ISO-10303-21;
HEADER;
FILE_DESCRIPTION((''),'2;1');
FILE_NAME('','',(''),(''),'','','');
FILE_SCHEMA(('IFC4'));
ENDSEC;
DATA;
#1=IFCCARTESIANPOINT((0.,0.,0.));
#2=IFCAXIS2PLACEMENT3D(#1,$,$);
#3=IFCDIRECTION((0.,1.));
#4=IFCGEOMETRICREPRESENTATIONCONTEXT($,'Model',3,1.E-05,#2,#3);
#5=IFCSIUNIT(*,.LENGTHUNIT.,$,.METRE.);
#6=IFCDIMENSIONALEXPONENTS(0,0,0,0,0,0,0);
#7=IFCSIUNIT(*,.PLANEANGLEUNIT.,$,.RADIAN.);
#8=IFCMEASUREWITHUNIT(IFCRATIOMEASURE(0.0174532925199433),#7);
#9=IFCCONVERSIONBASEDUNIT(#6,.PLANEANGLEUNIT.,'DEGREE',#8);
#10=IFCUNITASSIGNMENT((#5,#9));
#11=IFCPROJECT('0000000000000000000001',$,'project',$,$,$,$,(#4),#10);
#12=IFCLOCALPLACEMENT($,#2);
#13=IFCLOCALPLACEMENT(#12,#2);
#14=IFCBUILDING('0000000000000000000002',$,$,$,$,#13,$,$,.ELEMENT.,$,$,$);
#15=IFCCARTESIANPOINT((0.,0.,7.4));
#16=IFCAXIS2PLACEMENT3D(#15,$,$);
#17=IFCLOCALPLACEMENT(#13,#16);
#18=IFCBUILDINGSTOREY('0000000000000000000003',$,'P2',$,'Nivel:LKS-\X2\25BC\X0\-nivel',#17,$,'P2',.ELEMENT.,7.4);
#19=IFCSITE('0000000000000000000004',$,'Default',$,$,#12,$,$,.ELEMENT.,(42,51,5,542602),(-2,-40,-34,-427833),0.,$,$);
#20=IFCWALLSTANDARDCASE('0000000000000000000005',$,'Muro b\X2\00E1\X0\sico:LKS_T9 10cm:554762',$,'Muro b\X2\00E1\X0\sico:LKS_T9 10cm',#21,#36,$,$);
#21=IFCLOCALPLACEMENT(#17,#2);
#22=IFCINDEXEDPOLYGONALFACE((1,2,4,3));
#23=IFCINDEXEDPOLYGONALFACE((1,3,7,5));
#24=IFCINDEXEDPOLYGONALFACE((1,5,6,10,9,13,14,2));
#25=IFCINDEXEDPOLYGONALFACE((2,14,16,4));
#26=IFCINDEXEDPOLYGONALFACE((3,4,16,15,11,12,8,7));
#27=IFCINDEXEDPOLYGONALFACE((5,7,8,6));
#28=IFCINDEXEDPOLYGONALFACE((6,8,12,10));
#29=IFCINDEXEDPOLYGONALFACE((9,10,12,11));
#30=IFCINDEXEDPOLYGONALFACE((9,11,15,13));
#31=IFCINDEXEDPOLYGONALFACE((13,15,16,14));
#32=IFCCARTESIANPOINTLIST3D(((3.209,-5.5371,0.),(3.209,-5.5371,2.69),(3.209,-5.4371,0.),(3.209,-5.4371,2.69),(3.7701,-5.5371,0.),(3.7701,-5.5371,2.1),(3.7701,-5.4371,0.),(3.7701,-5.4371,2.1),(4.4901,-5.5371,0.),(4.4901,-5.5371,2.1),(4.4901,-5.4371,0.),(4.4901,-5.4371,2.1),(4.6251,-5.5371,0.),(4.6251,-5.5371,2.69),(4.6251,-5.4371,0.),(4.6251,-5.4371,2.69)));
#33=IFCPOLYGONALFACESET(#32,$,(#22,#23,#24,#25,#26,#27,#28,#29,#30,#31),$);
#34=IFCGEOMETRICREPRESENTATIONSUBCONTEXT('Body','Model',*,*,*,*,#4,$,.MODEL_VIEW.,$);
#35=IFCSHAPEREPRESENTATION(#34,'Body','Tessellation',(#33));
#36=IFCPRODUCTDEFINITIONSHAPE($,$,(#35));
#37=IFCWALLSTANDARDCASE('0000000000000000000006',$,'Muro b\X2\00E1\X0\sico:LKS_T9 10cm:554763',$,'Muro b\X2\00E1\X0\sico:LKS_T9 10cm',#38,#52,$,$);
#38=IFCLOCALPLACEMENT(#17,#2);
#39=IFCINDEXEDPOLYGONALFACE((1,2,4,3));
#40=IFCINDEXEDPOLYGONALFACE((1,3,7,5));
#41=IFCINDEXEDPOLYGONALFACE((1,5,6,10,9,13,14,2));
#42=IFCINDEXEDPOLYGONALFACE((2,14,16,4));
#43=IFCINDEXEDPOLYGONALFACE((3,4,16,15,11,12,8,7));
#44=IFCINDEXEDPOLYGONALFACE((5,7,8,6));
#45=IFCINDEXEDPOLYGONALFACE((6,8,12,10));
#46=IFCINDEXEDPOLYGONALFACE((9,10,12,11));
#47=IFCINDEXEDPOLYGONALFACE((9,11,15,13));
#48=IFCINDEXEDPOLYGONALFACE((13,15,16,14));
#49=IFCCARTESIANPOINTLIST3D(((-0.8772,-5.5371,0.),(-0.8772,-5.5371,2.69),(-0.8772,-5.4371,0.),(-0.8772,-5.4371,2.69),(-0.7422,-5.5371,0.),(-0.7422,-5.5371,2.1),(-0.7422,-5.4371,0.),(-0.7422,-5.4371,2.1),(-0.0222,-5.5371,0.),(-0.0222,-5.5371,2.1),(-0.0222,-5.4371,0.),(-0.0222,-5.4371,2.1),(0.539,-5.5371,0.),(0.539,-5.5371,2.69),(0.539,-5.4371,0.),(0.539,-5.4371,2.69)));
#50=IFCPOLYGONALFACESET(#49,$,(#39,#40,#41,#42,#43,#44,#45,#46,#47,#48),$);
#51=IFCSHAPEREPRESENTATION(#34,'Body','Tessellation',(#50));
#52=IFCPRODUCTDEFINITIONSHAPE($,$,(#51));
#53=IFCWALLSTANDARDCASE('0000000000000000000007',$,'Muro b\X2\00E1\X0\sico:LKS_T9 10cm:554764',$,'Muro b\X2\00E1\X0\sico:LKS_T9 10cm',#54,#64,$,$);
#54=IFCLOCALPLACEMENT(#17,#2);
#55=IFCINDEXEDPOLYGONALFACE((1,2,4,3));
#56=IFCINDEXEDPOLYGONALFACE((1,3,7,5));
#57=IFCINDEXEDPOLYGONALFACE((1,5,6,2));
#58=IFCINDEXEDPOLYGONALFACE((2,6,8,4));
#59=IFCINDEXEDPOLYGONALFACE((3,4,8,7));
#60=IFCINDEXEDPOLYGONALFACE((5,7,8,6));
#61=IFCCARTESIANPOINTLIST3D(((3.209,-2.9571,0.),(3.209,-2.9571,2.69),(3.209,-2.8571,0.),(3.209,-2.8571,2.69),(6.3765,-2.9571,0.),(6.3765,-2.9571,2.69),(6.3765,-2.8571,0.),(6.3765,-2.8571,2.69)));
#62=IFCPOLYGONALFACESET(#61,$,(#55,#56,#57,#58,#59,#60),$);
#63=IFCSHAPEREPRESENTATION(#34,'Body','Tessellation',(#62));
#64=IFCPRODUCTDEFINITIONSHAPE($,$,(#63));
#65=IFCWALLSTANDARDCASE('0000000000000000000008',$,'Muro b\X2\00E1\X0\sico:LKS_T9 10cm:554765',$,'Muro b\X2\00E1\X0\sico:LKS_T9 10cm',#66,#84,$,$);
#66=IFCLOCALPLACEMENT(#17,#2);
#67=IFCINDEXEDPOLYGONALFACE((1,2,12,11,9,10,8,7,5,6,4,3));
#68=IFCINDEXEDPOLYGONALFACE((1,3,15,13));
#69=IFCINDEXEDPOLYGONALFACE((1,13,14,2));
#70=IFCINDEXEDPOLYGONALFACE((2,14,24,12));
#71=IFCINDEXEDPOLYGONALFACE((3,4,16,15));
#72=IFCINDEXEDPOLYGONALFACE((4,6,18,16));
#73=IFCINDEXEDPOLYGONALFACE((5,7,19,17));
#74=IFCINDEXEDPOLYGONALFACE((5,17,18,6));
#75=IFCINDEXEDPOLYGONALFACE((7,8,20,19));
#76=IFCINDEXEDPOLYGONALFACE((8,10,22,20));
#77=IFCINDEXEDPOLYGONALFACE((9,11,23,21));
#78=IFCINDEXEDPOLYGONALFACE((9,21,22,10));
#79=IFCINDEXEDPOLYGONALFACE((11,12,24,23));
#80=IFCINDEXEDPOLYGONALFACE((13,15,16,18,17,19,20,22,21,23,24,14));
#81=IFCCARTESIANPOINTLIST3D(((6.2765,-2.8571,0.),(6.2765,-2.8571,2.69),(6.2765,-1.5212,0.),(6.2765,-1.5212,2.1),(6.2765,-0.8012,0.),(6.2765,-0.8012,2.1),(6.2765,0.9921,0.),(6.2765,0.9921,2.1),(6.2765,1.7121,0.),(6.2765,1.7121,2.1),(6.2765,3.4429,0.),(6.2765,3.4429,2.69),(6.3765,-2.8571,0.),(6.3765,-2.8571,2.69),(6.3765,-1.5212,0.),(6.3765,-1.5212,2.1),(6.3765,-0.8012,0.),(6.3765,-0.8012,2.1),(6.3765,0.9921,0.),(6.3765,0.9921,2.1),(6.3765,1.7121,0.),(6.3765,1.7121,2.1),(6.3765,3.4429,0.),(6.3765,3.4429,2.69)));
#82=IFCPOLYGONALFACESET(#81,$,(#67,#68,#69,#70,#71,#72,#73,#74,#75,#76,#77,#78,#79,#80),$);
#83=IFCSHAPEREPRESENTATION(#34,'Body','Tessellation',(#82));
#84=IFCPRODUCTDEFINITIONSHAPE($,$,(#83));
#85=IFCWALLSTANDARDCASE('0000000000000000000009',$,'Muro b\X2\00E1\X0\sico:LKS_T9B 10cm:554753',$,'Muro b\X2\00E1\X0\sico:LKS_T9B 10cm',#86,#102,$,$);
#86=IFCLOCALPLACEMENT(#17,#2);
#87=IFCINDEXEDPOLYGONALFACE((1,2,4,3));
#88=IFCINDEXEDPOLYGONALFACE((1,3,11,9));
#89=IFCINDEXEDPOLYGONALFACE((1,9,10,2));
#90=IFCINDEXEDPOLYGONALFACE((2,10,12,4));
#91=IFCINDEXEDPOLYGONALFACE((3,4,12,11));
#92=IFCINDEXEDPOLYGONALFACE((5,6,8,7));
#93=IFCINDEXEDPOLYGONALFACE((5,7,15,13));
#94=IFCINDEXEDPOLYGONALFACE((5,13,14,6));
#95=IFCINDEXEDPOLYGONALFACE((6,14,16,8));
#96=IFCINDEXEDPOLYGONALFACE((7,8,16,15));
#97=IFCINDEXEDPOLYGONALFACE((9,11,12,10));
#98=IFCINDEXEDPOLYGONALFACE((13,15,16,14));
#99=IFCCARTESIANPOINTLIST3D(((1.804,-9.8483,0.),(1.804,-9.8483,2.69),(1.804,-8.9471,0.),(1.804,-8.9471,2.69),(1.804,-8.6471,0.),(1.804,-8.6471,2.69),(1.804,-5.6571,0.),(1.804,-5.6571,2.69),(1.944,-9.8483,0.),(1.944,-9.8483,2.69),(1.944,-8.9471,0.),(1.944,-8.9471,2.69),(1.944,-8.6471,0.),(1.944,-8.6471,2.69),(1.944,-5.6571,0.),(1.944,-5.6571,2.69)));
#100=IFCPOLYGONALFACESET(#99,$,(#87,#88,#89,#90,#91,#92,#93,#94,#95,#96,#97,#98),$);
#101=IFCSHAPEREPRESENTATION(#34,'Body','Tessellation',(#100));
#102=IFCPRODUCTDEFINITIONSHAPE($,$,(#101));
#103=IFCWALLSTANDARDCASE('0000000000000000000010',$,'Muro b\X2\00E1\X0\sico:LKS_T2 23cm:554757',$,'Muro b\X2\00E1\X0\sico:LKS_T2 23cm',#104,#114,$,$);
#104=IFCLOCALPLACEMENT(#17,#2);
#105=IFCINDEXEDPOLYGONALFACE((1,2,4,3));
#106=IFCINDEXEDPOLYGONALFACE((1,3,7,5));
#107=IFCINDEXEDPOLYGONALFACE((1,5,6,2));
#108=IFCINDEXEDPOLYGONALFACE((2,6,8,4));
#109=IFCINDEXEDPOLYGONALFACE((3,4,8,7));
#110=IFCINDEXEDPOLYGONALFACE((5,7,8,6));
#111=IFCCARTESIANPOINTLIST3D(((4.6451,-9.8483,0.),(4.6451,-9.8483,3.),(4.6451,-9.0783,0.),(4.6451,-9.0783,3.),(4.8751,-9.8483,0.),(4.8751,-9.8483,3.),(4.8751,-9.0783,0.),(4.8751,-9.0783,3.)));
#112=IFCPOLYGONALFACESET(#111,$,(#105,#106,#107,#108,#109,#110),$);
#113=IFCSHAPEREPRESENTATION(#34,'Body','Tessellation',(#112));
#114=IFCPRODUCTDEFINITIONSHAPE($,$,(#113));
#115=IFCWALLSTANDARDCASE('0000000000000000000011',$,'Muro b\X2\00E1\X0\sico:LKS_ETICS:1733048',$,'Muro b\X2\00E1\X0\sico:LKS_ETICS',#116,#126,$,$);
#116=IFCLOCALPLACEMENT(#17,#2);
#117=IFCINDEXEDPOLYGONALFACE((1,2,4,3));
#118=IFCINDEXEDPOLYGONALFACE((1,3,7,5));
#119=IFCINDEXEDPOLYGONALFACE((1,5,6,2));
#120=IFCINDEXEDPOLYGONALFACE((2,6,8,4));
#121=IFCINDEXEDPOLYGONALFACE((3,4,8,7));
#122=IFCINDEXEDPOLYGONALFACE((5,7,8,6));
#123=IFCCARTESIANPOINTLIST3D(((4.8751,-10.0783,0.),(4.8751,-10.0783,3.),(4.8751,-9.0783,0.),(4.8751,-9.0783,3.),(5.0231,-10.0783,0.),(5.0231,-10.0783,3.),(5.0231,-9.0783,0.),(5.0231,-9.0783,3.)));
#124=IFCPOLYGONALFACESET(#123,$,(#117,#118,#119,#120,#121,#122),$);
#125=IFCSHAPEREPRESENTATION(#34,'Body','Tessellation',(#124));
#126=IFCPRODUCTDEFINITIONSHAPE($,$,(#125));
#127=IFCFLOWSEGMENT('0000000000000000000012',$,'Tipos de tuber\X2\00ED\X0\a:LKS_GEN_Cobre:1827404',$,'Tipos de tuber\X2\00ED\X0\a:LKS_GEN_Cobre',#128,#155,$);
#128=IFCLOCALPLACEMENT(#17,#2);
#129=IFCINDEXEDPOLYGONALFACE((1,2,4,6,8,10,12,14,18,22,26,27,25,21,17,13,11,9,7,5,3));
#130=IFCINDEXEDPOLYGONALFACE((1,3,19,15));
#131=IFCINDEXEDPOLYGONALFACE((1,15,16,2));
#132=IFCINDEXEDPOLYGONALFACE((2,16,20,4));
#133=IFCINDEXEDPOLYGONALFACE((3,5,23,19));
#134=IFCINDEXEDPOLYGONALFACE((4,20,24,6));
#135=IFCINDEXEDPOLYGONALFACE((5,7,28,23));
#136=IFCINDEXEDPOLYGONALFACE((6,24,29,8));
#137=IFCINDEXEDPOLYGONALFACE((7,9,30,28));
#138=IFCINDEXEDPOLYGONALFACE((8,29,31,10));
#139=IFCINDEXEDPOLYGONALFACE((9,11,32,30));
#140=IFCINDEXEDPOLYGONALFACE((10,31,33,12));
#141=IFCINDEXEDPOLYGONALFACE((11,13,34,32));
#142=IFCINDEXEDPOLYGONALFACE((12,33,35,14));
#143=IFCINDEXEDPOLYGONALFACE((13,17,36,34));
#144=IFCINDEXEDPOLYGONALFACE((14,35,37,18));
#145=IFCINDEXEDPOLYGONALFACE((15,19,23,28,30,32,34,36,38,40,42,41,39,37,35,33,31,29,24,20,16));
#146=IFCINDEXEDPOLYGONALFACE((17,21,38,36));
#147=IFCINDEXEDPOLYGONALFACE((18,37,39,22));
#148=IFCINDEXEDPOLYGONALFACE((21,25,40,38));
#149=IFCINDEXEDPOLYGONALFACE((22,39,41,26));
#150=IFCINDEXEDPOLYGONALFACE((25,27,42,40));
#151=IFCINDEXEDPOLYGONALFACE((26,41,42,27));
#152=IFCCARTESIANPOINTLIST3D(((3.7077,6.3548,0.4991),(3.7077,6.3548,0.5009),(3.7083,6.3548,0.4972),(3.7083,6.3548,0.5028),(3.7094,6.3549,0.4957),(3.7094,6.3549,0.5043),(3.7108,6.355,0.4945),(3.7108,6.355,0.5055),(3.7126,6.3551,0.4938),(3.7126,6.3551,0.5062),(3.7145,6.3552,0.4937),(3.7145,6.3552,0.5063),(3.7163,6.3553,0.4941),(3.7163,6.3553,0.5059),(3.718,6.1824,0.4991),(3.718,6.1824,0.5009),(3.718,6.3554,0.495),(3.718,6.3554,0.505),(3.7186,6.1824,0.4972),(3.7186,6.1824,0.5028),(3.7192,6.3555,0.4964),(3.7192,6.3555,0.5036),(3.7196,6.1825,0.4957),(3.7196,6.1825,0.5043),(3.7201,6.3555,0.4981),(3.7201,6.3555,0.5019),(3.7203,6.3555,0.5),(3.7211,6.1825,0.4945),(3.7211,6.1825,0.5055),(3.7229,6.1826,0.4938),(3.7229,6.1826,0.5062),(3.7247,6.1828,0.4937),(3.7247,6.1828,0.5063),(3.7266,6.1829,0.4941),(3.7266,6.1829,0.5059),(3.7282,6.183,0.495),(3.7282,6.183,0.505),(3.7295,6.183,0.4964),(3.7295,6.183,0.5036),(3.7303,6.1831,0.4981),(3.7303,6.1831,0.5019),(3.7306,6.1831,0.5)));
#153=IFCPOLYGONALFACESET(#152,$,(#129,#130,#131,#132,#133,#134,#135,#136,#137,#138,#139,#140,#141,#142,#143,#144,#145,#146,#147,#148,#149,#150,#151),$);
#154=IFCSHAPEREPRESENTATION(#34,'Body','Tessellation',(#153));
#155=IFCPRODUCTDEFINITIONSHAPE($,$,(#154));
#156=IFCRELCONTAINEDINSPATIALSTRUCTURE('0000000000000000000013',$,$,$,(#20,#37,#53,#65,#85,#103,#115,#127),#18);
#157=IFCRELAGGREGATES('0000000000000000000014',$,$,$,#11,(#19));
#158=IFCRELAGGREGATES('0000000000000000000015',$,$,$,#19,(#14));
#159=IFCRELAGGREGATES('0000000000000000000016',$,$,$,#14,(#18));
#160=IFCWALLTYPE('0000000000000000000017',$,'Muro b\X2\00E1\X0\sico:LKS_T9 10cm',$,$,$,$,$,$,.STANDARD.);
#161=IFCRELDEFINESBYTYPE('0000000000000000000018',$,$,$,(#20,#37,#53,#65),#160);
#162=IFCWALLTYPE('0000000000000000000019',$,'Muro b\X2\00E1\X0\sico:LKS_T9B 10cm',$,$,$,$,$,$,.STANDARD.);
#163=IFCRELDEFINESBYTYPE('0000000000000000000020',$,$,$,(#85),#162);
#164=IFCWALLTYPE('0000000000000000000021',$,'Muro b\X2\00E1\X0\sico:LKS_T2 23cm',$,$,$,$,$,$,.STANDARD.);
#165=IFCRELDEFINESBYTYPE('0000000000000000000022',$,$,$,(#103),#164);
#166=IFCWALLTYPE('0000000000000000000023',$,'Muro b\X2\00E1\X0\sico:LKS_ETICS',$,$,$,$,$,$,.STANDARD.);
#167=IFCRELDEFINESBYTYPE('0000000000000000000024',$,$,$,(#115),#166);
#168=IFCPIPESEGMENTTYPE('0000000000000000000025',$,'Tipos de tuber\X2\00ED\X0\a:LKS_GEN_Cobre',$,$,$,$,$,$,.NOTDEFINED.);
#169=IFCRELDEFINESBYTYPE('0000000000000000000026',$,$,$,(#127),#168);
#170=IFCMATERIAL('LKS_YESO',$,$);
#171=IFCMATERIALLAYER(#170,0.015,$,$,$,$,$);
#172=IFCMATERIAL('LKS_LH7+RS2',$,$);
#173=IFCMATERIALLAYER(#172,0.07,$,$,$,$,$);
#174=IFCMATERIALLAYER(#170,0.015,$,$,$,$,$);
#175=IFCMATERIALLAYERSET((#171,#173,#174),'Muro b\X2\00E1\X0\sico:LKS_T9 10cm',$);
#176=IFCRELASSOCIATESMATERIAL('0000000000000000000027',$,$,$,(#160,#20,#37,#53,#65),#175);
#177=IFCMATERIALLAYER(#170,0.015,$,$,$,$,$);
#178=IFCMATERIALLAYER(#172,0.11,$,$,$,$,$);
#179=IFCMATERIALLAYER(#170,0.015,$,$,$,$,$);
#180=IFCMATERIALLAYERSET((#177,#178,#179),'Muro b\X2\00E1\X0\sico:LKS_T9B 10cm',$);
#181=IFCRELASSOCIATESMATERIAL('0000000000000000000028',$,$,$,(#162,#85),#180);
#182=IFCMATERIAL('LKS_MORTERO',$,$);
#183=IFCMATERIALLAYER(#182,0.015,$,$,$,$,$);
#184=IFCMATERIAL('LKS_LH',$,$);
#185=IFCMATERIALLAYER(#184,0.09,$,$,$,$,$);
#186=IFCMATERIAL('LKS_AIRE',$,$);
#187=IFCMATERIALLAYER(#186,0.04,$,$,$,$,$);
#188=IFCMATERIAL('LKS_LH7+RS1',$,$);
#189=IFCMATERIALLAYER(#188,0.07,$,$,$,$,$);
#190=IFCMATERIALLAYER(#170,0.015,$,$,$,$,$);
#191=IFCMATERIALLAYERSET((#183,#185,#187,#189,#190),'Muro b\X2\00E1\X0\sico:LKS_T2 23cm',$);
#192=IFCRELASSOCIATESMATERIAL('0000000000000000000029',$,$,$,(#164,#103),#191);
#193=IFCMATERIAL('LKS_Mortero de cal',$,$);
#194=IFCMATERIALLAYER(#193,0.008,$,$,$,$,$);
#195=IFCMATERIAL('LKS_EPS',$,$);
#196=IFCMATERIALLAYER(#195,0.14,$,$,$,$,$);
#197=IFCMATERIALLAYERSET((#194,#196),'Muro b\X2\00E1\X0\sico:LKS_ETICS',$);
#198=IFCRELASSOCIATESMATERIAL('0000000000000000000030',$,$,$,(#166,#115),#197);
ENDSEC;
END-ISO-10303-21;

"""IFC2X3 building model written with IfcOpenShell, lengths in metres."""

from ifc_helpers import new_model, entity, si_unit, converted_unit, direction, frame, frame_2d, origin, origin_2d_with_axis, place, context, subcontext, project, spatial, rectangle, circle, extrude, material, layer, layer_set, layer_usage, type_object, element, save


model = new_model("IFC2X3")

# Units and contexts
model_context = context("Model", 3, precision=1e-05, world=origin(), true_north=direction((0.0, 1.0)))
body_context = subcontext(model_context, "Body", "Model", "MODEL_VIEW")
ifc_project = project(units=[si_unit("LENGTHUNIT", "METRE"), converted_unit("PLANEANGLEUNIT", "DEGREE", entity("IfcRatioMeasure", 0.0174532925199433), si_unit("PLANEANGLEUNIT", "RADIAN"), dimensions=[0, 0, 0, 0, 0, 0, 0])], contexts=[model_context])

# Site, building, storey
site_placement = place(None, origin())
site = spatial("IfcSite", under=ifc_project, at=site_placement, Name="Default", CompositionType="ELEMENT", RefLatitude=(42, 51, 5, 542602), RefLongitude=(-2, -40, -34, -427833), RefElevation=0.0)
building_placement = place(site_placement, origin())
building = spatial("IfcBuilding", under=site, at=building_placement, CompositionType="ELEMENT")
storey_placement = place(building_placement, frame((0.0, 0.0, 7.4)))
storey = spatial("IfcBuildingStorey", under=building, at=storey_placement, Name="P2", ObjectType="Nivel:LKS-▼-nivel", LongName="P2", CompositionType="ELEMENT", Elevation=7.4)

# Shared definitions
ifc_material_1 = material(Name="LKS_MORTERO")
ifc_material_2 = material(Name="LKS_LH")
ifc_material_3 = material(Name="LKS_AIRE")
ifc_material_4 = material(Name="LKS_LH7+RS2")
ifc_material_5 = material(Name="LKS_YESO")

# Shared definitions
ifc_material_6 = material(Name="LKS_LH7+RS1")

# Shared definitions
ifc_layer_1 = layer(ifc_material_5, 0.015)
ifc_layer_2 = layer(ifc_material_4, 0.07)
ifc_layer_3 = layer(ifc_material_5, 0.015)
ifc_layer_set_1 = layer_set([ifc_layer_1, ifc_layer_2, ifc_layer_3], Name="Muro básico:LKS_T9 10cm")
wall_type_1 = type_object("IfcWallType", Name="Muro básico:LKS_T9 10cm", PredefinedType="STANDARD", material=ifc_layer_set_1)

# Walls, openings
ifc_layer_usage_1 = layer_usage(ifc_layer_set_1, "AXIS2", "POSITIVE", -0.05)
wall_1_placement = place(storey_placement, frame((3.209, -5.4871, 0.0)))
wall_1 = element("IfcWallStandardCase", 1, at=wall_1_placement, inside=storey, type_object=wall_type_1, material=ifc_layer_usage_1, Name="Muro básico:LKS_T9 10cm:554762", ObjectType="Muro básico:LKS_T9 10cm", context=body_context, shape_type="SweptSolid", body=[
    extrude(rectangle(XDim=1.4161, YDim=0.1, at=frame_2d((0.7081, 0.0), x_axis=(-1.0, 0.0))), origin(), (0.0, 0.0, 1.0), 2.69),
])
opening_1_placement = place(wall_1_placement, frame((1.2811, 0.05, 0.0)))
element("IfcOpeningElement", 2, at=opening_1_placement, cuts=wall_1, ObjectType="Opening", context=body_context, shape_type="SweptSolid", body=[
    extrude(rectangle(XDim=2.1, YDim=0.72, at=frame_2d((1.05, 0.36), x_axis=(1.0, 0.0))), frame((0.0, 0.0, 0.0), z_axis=(0.0, -1.0, 0.0), x_axis=(0.0, 0.0, 1.0)), (0.0, 0.0, 1.0), 0.1),
])
ifc_layer_usage_2 = layer_usage(ifc_layer_set_1, "AXIS2", "NEGATIVE", 0.05)
wall_2_placement = place(storey_placement, frame((0.539, -5.4871, 0.0), z_axis=(0.0, 0.0, 1.0), x_axis=(-1.0, 0.0, 0.0)))
wall_2 = element("IfcWallStandardCase", 3, at=wall_2_placement, inside=storey, type_object=wall_type_1, material=ifc_layer_usage_2, Name="Muro básico:LKS_T9 10cm:554763", ObjectType="Muro básico:LKS_T9 10cm", context=body_context, shape_type="SweptSolid", body=[
    extrude(rectangle(XDim=1.4161, YDim=0.1, at=frame_2d((0.7081, 0.0), x_axis=(-1.0, 0.0))), origin(), (0.0, 0.0, 1.0), 2.69),
])
opening_2_placement = place(wall_2_placement, frame((0.5611, -0.05, 0.0)))
element("IfcOpeningElement", 4, at=opening_2_placement, cuts=wall_2, ObjectType="Opening", context=body_context, shape_type="SweptSolid", body=[
    extrude(rectangle(XDim=2.1, YDim=0.72, at=frame_2d((1.05, 0.36), x_axis=(1.0, 0.0))), frame((0.0, 0.0, 0.0), z_axis=(0.0, 1.0, 0.0), x_axis=(0.0, 0.0, 1.0)), (0.0, 0.0, 1.0), 0.1),
])

# Wall
ifc_layer_usage_3 = layer_usage(ifc_layer_set_1, "AXIS2", "NEGATIVE", 0.05)
wall_3_placement = place(storey_placement, frame((3.209, -2.9071, 0.0)))
element("IfcWallStandardCase", 5, at=wall_3_placement, inside=storey, type_object=wall_type_1, material=ifc_layer_usage_3, Name="Muro básico:LKS_T9 10cm:554764", ObjectType="Muro básico:LKS_T9 10cm", context=body_context, shape_type="SweptSolid", body=[
    extrude(rectangle(XDim=3.1676, YDim=0.1, at=frame_2d((1.5838, 0.0), x_axis=(-1.0, 0.0))), origin(), (0.0, 0.0, 1.0), 2.69),
])

# Wall, openings
ifc_layer_usage_4 = layer_usage(ifc_layer_set_1, "AXIS2", "NEGATIVE", 0.05)
wall_4_placement = place(storey_placement, frame((6.3265, -2.8571, 0.0), z_axis=(0.0, 0.0, 1.0), x_axis=(0.0, 1.0, 0.0)))
wall_4 = element("IfcWallStandardCase", 6, at=wall_4_placement, inside=storey, type_object=wall_type_1, material=ifc_layer_usage_4, Name="Muro básico:LKS_T9 10cm:554765", ObjectType="Muro básico:LKS_T9 10cm", context=body_context, shape_type="SweptSolid", body=[
    extrude(rectangle(XDim=6.3, YDim=0.1, at=frame_2d((3.15, 0.0), x_axis=(-1.0, 0.0))), origin(), (0.0, 0.0, 1.0), 2.69),
])
opening_3_placement = place(wall_4_placement, frame((1.3359, -0.05, 0.0)))
element("IfcOpeningElement", 7, at=opening_3_placement, cuts=wall_4, ObjectType="Opening", context=body_context, shape_type="SweptSolid", body=[
    extrude(rectangle(XDim=2.1, YDim=0.72, at=frame_2d((1.05, 0.36), x_axis=(1.0, 0.0))), frame((0.0, 0.0, 0.0), z_axis=(0.0, 1.0, 0.0), x_axis=(0.0, 0.0, 1.0)), (0.0, 0.0, 1.0), 0.1),
])
opening_4_placement = place(wall_4_placement, frame((3.8492, -0.05, 0.0)))
element("IfcOpeningElement", 8, at=opening_4_placement, cuts=wall_4, ObjectType="Opening", context=body_context, shape_type="SweptSolid", body=[
    extrude(rectangle(XDim=2.1, YDim=0.72, at=frame_2d((1.05, 0.36), x_axis=(1.0, 0.0))), frame((0.0, 0.0, 0.0), z_axis=(0.0, 1.0, 0.0), x_axis=(0.0, 0.0, 1.0)), (0.0, 0.0, 1.0), 0.1),
])

# Wall, opening
ifc_layer_4 = layer(ifc_material_5, 0.015)
ifc_layer_5 = layer(ifc_material_4, 0.11)
ifc_layer_6 = layer(ifc_material_5, 0.015)
ifc_layer_set_2 = layer_set([ifc_layer_4, ifc_layer_5, ifc_layer_6], Name="Muro básico:LKS_T9B 10cm")
ifc_layer_usage_5 = layer_usage(ifc_layer_set_2, "AXIS2", "NEGATIVE", 0.07)
wall_type_2 = type_object("IfcWallType", Name="Muro básico:LKS_T9B 10cm", PredefinedType="STANDARD", material=ifc_layer_set_2)
wall_5_placement = place(storey_placement, frame((1.874, -5.6571, 0.0), z_axis=(0.0, 0.0, 1.0), x_axis=(0.0, -1.0, 0.0)))
wall_5 = element("IfcWallStandardCase", 9, at=wall_5_placement, inside=storey, type_object=wall_type_2, material=ifc_layer_usage_5, Name="Muro básico:LKS_T9B 10cm:554753", ObjectType="Muro básico:LKS_T9B 10cm", context=body_context, shape_type="SweptSolid", body=[
    extrude(rectangle(XDim=4.1911, YDim=0.14, at=frame_2d((2.0956, 0.0), x_axis=(-1.0, 0.0))), origin(), (0.0, 0.0, 1.0), 2.69),
])
opening_5_placement = place(storey_placement, frame((1.874, -5.6571, 0.0), z_axis=(0.0, 0.0, 1.0), x_axis=(0.0, -1.0, 0.0)))
element("IfcOpeningElement", 10, at=opening_5_placement, cuts=wall_5, ObjectType="Opening", context=body_context, shape_type="SweptSolid", body=[
    extrude(rectangle(XDim=2.69, YDim=0.14, at=origin_2d_with_axis()), frame((3.29, 0.0, 1.345), z_axis=(-1.0, 0.0, 0.0), x_axis=(0.0, 0.0, 1.0)), (0.0, 0.0, 1.0), 0.3),
])

# Walls
ifc_layer_7 = layer(ifc_material_1, 0.015)
ifc_layer_8 = layer(ifc_material_2, 0.09)
ifc_layer_9 = layer(ifc_material_3, 0.04)
ifc_layer_10 = layer(ifc_material_6, 0.07)
ifc_layer_11 = layer(ifc_material_5, 0.015)
ifc_layer_set_3 = layer_set([ifc_layer_7, ifc_layer_8, ifc_layer_9, ifc_layer_10, ifc_layer_11], Name="Muro básico:LKS_T2 23cm")
ifc_layer_usage_6 = layer_usage(ifc_layer_set_3, "AXIS2", "POSITIVE", -0.115)
wall_type_3 = type_object("IfcWallType", Name="Muro básico:LKS_T2 23cm", PredefinedType="STANDARD", material=ifc_layer_set_3)
wall_6_placement = place(storey_placement, frame((4.7601, -9.8483, 0.0), z_axis=(0.0, 0.0, 1.0), x_axis=(0.0, 1.0, 0.0)))
element("IfcWallStandardCase", 11, at=wall_6_placement, inside=storey, type_object=wall_type_3, material=ifc_layer_usage_6, Name="Muro básico:LKS_T2 23cm:554757", ObjectType="Muro básico:LKS_T2 23cm", context=body_context, shape_type="SweptSolid", body=[
    extrude(rectangle(XDim=0.77, YDim=0.23, at=frame_2d((0.385, 0.0), x_axis=(-1.0, 0.0))), origin(), (0.0, 0.0, 1.0), 3.0),
])
ifc_material_7 = material(Name="LKS_Mortero de cal")
ifc_layer_12 = layer(ifc_material_7, 0.008)
ifc_material_8 = material(Name="LKS_EPS")
ifc_layer_13 = layer(ifc_material_8, 0.14)
ifc_layer_set_4 = layer_set([ifc_layer_12, ifc_layer_13], Name="Muro básico:LKS_ETICS")
ifc_layer_usage_7 = layer_usage(ifc_layer_set_4, "AXIS2", "POSITIVE", -0.074)
wall_type_4 = type_object("IfcWallType", Name="Muro básico:LKS_ETICS", PredefinedType="STANDARD", material=ifc_layer_set_4)
wall_7_placement = place(storey_placement, frame((4.9491, -10.0783, 0.0), z_axis=(0.0, 0.0, 1.0), x_axis=(0.0, 1.0, 0.0)))
element("IfcWallStandardCase", 12, at=wall_7_placement, inside=storey, type_object=wall_type_4, material=ifc_layer_usage_7, Name="Muro básico:LKS_ETICS:1733048", ObjectType="Muro básico:LKS_ETICS", context=body_context, shape_type="SweptSolid", body=[
    extrude(rectangle(XDim=1.0, YDim=0.148, at=frame_2d((0.5, 0.0), x_axis=(-1.0, 0.0))), origin(), (0.0, 0.0, 1.0), 3.0),
])

# Flow segment
pipe_segment_type_1 = type_object("IfcPipeSegmentType", Name="Tipos de tubería:LKS_GEN_Cobre", PredefinedType="NOTDEFINED")
flow_segment_1_placement = place(storey_placement, origin())
element("IfcFlowSegment", 13, at=flow_segment_1_placement, inside=storey, type_object=pipe_segment_type_1, Name="Tipos de tubería:LKS_GEN_Cobre:1827404", ObjectType="Tipos de tubería:LKS_GEN_Cobre", context=body_context, shape_type="SweptSolid", body=[
    extrude(circle(Radius=0.0063, at=origin_2d_with_axis()), frame((3.714, 6.3552, 0.5), z_axis=(0.059398, -0.998234, 0.0), x_axis=(0.998234, 0.059398, 0.0)), (0.0, 0.0, 1.0), 0.1727),
])

save(model, "model.ifc")
